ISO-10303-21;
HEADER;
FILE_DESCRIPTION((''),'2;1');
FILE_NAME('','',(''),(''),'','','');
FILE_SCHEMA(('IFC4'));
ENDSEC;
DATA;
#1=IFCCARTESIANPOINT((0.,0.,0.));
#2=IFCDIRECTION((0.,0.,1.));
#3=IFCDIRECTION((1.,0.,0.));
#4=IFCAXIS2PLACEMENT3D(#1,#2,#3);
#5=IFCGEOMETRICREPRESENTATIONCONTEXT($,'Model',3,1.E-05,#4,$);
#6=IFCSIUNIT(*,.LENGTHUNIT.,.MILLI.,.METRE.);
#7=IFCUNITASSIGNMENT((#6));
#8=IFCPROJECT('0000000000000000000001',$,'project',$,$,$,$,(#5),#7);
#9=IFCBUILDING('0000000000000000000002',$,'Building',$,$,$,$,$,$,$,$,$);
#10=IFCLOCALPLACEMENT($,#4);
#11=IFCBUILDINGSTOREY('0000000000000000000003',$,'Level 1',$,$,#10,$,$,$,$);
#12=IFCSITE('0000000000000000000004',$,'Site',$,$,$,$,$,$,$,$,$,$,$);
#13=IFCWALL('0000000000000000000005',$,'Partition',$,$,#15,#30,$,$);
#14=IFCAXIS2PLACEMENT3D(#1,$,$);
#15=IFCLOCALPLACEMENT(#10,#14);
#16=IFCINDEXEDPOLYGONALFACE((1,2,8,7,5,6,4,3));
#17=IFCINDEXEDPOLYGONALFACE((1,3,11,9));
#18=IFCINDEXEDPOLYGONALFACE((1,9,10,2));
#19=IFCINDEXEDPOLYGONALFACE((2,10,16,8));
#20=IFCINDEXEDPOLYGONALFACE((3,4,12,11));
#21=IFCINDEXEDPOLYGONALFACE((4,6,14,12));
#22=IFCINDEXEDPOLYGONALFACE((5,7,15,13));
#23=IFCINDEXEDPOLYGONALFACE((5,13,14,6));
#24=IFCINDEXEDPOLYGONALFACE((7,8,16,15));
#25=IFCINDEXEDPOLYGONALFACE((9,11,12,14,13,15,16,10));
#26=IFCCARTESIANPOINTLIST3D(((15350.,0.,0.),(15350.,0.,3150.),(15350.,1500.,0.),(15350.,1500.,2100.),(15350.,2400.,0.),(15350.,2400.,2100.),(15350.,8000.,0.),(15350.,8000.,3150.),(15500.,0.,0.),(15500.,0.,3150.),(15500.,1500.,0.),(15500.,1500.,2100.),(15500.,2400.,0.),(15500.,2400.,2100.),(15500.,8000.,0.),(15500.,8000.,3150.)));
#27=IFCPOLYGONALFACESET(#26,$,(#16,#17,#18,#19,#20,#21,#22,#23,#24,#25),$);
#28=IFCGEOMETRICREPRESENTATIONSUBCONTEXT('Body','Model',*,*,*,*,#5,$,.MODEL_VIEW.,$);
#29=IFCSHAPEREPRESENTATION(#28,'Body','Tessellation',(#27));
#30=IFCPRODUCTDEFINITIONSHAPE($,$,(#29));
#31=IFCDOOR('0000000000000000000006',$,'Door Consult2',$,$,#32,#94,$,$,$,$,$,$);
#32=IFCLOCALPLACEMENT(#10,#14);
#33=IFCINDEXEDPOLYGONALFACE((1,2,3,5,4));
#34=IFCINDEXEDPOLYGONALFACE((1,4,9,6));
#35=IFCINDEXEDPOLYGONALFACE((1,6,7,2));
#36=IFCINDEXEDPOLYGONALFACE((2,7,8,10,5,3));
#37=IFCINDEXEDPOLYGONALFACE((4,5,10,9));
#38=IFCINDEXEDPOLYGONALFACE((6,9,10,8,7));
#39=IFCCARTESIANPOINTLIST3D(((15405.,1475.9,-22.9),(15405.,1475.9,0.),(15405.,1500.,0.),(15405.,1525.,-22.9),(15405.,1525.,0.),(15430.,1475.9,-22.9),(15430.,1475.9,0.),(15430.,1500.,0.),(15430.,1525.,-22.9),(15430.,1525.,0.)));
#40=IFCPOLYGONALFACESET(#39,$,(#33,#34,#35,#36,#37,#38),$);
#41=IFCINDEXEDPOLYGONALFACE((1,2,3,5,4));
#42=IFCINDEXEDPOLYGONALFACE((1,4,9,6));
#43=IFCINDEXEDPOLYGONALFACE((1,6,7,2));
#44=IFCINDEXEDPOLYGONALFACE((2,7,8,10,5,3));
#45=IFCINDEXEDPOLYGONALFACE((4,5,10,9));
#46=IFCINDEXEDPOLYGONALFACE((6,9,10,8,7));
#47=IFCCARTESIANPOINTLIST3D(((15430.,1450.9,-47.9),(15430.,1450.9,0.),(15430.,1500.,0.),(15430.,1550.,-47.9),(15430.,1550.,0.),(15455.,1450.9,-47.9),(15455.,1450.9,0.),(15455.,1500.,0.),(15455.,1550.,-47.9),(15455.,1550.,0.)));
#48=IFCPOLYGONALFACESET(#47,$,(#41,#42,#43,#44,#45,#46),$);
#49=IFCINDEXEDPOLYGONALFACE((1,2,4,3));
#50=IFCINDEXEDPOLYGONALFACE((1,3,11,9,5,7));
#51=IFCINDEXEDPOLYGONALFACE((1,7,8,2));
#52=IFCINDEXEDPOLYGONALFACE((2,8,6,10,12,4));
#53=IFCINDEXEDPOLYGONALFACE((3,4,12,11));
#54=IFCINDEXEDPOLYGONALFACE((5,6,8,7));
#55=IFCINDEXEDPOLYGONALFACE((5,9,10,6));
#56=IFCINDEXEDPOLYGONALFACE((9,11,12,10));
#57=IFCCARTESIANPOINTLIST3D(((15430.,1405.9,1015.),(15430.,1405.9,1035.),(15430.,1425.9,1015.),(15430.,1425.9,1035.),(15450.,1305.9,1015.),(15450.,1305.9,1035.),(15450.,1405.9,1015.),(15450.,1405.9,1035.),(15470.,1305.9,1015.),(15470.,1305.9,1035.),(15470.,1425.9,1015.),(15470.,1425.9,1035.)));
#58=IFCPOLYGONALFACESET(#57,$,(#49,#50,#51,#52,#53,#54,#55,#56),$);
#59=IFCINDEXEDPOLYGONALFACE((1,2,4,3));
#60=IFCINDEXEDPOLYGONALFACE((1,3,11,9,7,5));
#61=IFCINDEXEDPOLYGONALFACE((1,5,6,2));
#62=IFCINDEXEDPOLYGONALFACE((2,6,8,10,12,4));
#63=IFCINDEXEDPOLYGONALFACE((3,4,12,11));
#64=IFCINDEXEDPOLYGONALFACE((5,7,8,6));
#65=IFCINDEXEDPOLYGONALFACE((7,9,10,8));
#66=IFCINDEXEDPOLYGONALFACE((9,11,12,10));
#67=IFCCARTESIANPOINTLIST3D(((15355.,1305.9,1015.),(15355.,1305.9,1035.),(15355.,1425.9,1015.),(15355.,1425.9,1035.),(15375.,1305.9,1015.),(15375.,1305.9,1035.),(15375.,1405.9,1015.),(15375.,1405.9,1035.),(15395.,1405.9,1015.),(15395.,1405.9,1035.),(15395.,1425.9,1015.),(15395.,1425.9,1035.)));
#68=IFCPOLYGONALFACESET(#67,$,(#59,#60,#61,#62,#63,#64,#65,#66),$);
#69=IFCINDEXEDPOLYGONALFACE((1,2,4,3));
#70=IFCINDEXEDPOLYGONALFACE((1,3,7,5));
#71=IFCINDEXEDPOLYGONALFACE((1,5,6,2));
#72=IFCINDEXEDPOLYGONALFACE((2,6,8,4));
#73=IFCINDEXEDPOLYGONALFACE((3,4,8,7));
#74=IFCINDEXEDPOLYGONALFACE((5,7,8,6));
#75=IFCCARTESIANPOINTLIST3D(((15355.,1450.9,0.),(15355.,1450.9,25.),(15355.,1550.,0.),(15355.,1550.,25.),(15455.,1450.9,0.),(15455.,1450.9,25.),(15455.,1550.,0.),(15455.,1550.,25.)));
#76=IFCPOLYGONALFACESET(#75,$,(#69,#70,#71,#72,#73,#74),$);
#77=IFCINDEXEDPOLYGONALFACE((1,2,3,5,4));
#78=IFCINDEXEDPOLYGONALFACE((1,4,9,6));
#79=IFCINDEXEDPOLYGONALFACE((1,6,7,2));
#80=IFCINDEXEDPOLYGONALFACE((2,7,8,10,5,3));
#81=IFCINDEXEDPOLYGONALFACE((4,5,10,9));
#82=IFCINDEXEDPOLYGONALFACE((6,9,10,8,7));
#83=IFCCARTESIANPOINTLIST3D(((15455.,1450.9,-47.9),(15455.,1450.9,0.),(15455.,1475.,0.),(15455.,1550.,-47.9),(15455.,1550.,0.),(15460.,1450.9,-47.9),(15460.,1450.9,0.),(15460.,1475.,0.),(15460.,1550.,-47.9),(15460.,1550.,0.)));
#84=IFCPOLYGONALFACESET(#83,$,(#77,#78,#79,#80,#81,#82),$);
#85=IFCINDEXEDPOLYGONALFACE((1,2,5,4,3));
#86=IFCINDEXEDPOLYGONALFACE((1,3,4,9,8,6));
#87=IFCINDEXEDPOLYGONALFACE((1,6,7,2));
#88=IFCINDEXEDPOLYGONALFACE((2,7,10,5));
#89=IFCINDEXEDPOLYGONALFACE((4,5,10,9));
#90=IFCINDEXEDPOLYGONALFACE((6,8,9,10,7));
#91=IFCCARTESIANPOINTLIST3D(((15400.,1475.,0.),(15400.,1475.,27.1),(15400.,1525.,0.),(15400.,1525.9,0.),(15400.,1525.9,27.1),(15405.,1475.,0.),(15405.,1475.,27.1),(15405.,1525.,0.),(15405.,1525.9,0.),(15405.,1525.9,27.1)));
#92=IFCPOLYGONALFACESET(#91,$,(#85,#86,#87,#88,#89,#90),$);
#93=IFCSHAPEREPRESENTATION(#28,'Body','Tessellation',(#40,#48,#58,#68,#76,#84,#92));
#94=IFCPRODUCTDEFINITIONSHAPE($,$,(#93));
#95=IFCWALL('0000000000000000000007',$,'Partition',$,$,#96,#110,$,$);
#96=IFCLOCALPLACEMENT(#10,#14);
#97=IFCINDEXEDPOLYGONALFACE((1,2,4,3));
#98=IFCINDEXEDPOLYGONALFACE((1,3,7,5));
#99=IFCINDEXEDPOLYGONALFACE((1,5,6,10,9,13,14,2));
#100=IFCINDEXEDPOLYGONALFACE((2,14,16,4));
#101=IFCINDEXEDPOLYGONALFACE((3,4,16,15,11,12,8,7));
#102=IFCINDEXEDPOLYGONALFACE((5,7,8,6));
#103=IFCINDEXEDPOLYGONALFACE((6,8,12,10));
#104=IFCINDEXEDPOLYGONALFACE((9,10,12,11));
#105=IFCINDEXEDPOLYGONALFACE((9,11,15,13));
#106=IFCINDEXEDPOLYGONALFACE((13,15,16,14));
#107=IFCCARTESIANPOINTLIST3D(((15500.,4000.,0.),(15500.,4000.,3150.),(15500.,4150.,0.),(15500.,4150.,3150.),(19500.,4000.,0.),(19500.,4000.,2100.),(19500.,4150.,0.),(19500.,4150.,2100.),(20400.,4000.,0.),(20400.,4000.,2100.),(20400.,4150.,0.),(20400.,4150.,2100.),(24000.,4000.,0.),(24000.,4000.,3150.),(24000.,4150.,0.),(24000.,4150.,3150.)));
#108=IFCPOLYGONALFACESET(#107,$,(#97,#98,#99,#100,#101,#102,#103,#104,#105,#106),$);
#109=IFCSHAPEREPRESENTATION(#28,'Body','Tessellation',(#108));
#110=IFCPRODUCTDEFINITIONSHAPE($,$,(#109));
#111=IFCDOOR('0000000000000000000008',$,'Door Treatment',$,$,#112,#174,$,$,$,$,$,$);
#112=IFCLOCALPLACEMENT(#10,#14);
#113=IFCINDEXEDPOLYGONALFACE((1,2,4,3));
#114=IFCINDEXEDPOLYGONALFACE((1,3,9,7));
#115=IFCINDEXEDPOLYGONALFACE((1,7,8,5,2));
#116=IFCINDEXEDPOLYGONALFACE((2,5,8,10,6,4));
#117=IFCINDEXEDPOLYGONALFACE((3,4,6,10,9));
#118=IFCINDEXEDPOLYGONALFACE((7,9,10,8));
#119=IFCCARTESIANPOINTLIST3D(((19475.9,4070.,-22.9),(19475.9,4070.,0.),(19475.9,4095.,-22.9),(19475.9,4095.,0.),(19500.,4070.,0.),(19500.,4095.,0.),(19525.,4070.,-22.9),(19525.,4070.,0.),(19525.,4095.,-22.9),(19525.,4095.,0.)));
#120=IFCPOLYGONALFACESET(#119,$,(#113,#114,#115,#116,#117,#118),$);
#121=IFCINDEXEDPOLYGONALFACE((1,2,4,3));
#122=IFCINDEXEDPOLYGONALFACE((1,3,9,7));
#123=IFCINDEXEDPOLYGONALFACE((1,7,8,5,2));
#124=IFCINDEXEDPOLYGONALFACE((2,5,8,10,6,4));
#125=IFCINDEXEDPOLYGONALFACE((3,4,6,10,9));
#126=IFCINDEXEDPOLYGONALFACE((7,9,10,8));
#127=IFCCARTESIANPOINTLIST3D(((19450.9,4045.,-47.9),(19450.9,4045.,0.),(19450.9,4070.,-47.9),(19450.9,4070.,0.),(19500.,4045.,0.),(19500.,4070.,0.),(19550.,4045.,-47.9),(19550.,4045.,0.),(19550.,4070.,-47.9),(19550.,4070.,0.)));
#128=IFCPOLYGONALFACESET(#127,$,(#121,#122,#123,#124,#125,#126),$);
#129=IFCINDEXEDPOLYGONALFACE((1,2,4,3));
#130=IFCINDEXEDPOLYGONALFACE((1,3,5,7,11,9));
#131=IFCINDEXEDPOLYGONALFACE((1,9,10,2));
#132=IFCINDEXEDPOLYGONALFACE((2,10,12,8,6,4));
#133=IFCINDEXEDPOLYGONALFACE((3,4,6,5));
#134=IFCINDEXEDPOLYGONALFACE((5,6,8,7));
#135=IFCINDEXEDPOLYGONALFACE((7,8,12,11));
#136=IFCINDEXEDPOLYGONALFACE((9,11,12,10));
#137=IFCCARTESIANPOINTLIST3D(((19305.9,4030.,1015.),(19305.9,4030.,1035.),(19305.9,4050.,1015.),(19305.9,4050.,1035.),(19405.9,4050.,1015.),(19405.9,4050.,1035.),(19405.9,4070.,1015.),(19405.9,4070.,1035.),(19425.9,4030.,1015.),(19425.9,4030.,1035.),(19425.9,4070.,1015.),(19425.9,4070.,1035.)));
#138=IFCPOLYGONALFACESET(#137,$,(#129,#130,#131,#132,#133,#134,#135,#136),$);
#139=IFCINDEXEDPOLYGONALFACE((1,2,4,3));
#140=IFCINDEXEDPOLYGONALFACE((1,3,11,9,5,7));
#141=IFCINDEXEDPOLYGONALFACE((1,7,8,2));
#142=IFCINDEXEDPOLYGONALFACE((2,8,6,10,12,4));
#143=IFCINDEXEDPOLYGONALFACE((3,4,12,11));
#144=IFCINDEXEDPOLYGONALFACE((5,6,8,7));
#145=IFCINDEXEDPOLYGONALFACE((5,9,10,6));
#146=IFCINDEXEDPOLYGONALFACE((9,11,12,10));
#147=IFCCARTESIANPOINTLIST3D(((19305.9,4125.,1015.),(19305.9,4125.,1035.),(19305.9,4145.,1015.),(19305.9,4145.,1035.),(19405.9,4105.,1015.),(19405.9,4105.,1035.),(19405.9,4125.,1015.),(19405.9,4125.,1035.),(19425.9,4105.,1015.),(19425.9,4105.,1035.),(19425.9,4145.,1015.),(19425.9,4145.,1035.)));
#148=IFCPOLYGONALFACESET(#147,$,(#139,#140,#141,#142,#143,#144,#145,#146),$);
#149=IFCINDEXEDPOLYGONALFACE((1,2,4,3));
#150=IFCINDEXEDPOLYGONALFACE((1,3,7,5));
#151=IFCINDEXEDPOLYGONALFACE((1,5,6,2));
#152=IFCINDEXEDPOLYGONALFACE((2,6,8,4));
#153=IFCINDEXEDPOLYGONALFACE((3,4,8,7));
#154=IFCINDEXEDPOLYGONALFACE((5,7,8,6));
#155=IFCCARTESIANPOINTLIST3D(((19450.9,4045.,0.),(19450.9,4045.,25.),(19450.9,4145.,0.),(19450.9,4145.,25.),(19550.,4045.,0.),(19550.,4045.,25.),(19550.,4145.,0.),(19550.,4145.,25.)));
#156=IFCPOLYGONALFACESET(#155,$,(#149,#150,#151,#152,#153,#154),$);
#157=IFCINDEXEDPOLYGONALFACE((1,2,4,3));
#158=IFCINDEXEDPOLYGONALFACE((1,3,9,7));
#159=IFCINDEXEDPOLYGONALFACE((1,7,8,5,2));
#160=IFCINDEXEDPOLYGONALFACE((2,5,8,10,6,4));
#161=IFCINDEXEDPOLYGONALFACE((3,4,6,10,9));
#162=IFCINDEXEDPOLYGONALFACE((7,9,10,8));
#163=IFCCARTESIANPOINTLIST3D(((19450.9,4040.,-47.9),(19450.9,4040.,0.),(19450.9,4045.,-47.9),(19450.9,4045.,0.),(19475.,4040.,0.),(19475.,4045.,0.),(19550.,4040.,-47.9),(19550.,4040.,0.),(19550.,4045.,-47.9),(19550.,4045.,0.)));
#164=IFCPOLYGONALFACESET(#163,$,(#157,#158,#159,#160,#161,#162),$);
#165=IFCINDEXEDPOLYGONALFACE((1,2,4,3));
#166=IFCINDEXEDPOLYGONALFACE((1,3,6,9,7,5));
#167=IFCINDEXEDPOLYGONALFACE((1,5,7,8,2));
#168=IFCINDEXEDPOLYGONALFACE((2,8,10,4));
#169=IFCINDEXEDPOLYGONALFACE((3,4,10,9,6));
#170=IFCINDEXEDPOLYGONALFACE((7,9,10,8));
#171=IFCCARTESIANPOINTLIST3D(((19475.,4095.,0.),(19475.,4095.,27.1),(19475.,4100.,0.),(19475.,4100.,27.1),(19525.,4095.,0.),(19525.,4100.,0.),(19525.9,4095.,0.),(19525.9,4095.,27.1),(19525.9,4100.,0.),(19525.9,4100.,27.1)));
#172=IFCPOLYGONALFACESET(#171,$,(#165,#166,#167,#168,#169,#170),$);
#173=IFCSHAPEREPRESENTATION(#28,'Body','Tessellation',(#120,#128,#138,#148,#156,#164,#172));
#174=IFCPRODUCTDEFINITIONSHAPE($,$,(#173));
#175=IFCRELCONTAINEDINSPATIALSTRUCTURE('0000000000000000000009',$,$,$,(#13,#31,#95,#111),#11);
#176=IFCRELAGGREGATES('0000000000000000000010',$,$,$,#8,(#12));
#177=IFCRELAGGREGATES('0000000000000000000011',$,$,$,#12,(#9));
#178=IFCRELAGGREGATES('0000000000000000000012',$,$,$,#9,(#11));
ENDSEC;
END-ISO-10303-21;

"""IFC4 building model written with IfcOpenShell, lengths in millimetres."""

from ifc_helpers import new_model, si_unit, frame, origin_with_axes, place, context, subcontext, project, spatial, line, indexed_curve, outline, extrude, element, fill, save


model = new_model("IFC4")

# Units and contexts
model_context = context("Model", 3, precision=1e-05, world=origin_with_axes())
body_context = subcontext(model_context, "Body", "Model", "MODEL_VIEW")
ifc_project = project(units=[si_unit("LENGTHUNIT", "METRE", prefix="MILLI")], contexts=[model_context])

# Site, building, storey
site = spatial("IfcSite", under=ifc_project, Name="Site")
building = spatial("IfcBuilding", under=site, Name="Building")
storey_placement = place(None, origin_with_axes())
storey = spatial("IfcBuildingStorey", under=building, at=storey_placement, Name="Level 1")

# Walls, openings, doors
wall_1_placement = place(storey_placement, frame((15500.0, 0.0, 0.0), z_axis=(0.0, 0.0, 1.0), x_axis=(0.0, 1.0, 0.0)))
wall_1 = element("IfcWall", 1, at=wall_1_placement, inside=storey, Name="Partition", context=body_context, shape_type="SweptSolid", body=[
    extrude(outline(indexed_curve([(0.0, 0.0), (0.0, 150.0), (8000.0, 150.0), (8000.0, 0.0), (0.0, 0.0)], self_intersect=False)), origin_with_axes(), (0.0, 0.0, 1.0), 3150.0),
])
opening_1_placement = place(wall_1_placement, frame((1500.0, -100.0, 0.0), z_axis=(0.0, 0.0, 1.0), x_axis=(1.0, 0.0, 0.0)))
opening_1 = element("IfcOpeningElement", 2, at=opening_1_placement, cuts=wall_1, context=body_context, shape_type="SweptSolid", body=[
    extrude(outline(indexed_curve([(0.0, 0.0), (0.0, 350.0), (900.0, 350.0), (900.0, 0.0), (0.0, 0.0)], self_intersect=False)), origin_with_axes(), (0.0, 0.0, 1.0), 2100.0),
])
door_1_placement = place(opening_1_placement, frame((0.0, 145.0, 0.0), z_axis=(0.0, 0.0, 1.0), x_axis=(1.0, 0.0, 0.0)))
door_1 = element("IfcDoor", 3, at=door_1_placement, inside=storey, Name="Door Consult2", context=body_context, shape_type="SweptSolid", body=[
    extrude(outline(indexed_curve([(0.0, 0.0), (0.0, 2.1), (0.9, 2.1), (0.9, 0.0), (-24.1, 0.0), (-24.1, -22.9), (25.0, -22.9), (25.0, 0.0)], segments=[line(1, 2, 3, 4, 5, 6, 7, 8, 1)])), frame((0.0, 25.0, 0.0), z_axis=(0.0, -1.0, 0.0), x_axis=(1.0, 0.0, 0.0)), (0.0, 0.0, -1.0), 25.0),
    extrude(outline(indexed_curve([(0.0, 0.0), (0.0, 2.1), (0.9, 2.1), (0.9, 0.0), (-49.1, 0.0), (-49.1, -47.9), (50.0, -47.9), (50.0, 0.0)], segments=[line(1, 2, 3, 4, 5, 6, 7, 8, 1)])), frame((0.0, 0.0, 0.0), z_axis=(0.0, -1.0, 0.0), x_axis=(1.0, 0.0, 0.0)), (0.0, 0.0, -1.0), 25.0),
    extrude(outline(indexed_curve([(0.0, 0.0), (-49.1, 0.0), (-49.1, 35.0), (0.0, 35.0)], segments=[line(1, 2, 3, 4, 1)])), frame((25.0, 25.0, 25.0), z_axis=(0.0, 0.0, 1.0), x_axis=(1.0, 0.0, 0.0)), (0.0, 0.0, 1.0), -47.9),
    extrude(outline(indexed_curve([(0.0, 0.0), (0.0, -40.0), (-120.0, -40.0), (-120.0, -20.0), (-20.0, -20.0), (-20.0, 0.0)], segments=[line(1, 2, 3, 4, 5, 6, 1)])), frame((-74.1, 25.0, 1015.0), z_axis=(0.0, 0.0, 1.0), x_axis=(1.0, 0.0, 0.0)), (0.0, 0.0, 1.0), 20.0),
    extrude(outline(indexed_curve([(0.0, 0.0), (0.0, 40.0), (-120.0, 40.0), (-120.0, 20.0), (-20.0, 20.0), (-20.0, 0.0)], segments=[line(1, 2, 3, 4, 5, 6, 1)])), frame((-74.1, 60.0, 1015.0), z_axis=(0.0, 0.0, 1.0), x_axis=(1.0, 0.0, 0.0)), (0.0, 0.0, 1.0), 20.0),
    extrude(outline(indexed_curve([(0.0, 0.0), (-99.1, 0.0), (-99.1, 100.0), (0.0, 100.0)], segments=[line(1, 2, 3, 4, 1)])), frame((50.0, 0.0, 0.0), z_axis=(0.0, 0.0, 1.0), x_axis=(1.0, 0.0, 0.0)), (0.0, 0.0, 1.0), 25.0),
    extrude(outline(indexed_curve([(0.0, 0.0), (0.0, 27.1), (50.9, 27.1), (50.9, 0.0), (-24.1, 0.0), (-24.1, -47.9), (75.0, -47.9), (75.0, 0.0)], segments=[line(1, 2, 3, 4, 5, 6, 7, 8, 1)])), frame((-25.0, -5.0, 0.0), z_axis=(0.0, -1.0, 0.0), x_axis=(1.0, 0.0, 0.0)), (0.0, 0.0, -1.0), 5.0),
    extrude(outline(indexed_curve([(0.0, 0.0), (0.0, 27.1), (50.9, 27.1), (50.9, 0.0), (0.9, 0.0), (0.9, -22.9), (50.0, -22.9), (50.0, 0.0)], segments=[line(1, 2, 3, 4, 5, 6, 7, 8, 1)])), frame((-25.0, 50.0, 0.0), z_axis=(0.0, -1.0, 0.0), x_axis=(1.0, 0.0, 0.0)), (0.0, 0.0, -1.0), 5.0),
])
fill(opening_1, door_1)
wall_2_placement = place(storey_placement, frame((15500.0, 4000.0, 0.0), z_axis=(0.0, 0.0, 1.0), x_axis=(1.0, 0.0, 0.0)))
wall_2 = element("IfcWall", 4, at=wall_2_placement, inside=storey, Name="Partition", context=body_context, shape_type="SweptSolid", body=[
    extrude(outline(indexed_curve([(0.0, 0.0), (0.0, 150.0), (8500.0, 150.0), (8500.0, 0.0), (0.0, 0.0)], self_intersect=False)), origin_with_axes(), (0.0, 0.0, 1.0), 3150.0),
])
opening_2_placement = place(wall_2_placement, frame((4000.0, -100.0, 0.0), z_axis=(0.0, 0.0, 1.0), x_axis=(1.0, 0.0, 0.0)))
opening_2 = element("IfcOpeningElement", 5, at=opening_2_placement, cuts=wall_2, context=body_context, shape_type="SweptSolid", body=[
    extrude(outline(indexed_curve([(0.0, 0.0), (0.0, 350.0), (900.0, 350.0), (900.0, 0.0), (0.0, 0.0)], self_intersect=False)), origin_with_axes(), (0.0, 0.0, 1.0), 2100.0),
])
door_2_placement = place(opening_2_placement, frame((0.0, 145.0, 0.0), z_axis=(0.0, 0.0, 1.0), x_axis=(1.0, 0.0, 0.0)))
door_2 = element("IfcDoor", 6, at=door_2_placement, inside=storey, Name="Door Treatment", context=body_context, shape_type="SweptSolid", body=[
    extrude(outline(indexed_curve([(0.0, 0.0), (0.0, 2.1), (0.9, 2.1), (0.9, 0.0), (-24.1, 0.0), (-24.1, -22.9), (25.0, -22.9), (25.0, 0.0)], segments=[line(1, 2, 3, 4, 5, 6, 7, 8, 1)])), frame((0.0, 25.0, 0.0), z_axis=(0.0, -1.0, 0.0), x_axis=(1.0, 0.0, 0.0)), (0.0, 0.0, -1.0), 25.0),
    extrude(outline(indexed_curve([(0.0, 0.0), (0.0, 2.1), (0.9, 2.1), (0.9, 0.0), (-49.1, 0.0), (-49.1, -47.9), (50.0, -47.9), (50.0, 0.0)], segments=[line(1, 2, 3, 4, 5, 6, 7, 8, 1)])), frame((0.0, 0.0, 0.0), z_axis=(0.0, -1.0, 0.0), x_axis=(1.0, 0.0, 0.0)), (0.0, 0.0, -1.0), 25.0),
    extrude(outline(indexed_curve([(0.0, 0.0), (-49.1, 0.0), (-49.1, 35.0), (0.0, 35.0)], segments=[line(1, 2, 3, 4, 1)])), frame((25.0, 25.0, 25.0), z_axis=(0.0, 0.0, 1.0), x_axis=(1.0, 0.0, 0.0)), (0.0, 0.0, 1.0), -47.9),
    extrude(outline(indexed_curve([(0.0, 0.0), (0.0, -40.0), (-120.0, -40.0), (-120.0, -20.0), (-20.0, -20.0), (-20.0, 0.0)], segments=[line(1, 2, 3, 4, 5, 6, 1)])), frame((-74.1, 25.0, 1015.0), z_axis=(0.0, 0.0, 1.0), x_axis=(1.0, 0.0, 0.0)), (0.0, 0.0, 1.0), 20.0),
    extrude(outline(indexed_curve([(0.0, 0.0), (0.0, 40.0), (-120.0, 40.0), (-120.0, 20.0), (-20.0, 20.0), (-20.0, 0.0)], segments=[line(1, 2, 3, 4, 5, 6, 1)])), frame((-74.1, 60.0, 1015.0), z_axis=(0.0, 0.0, 1.0), x_axis=(1.0, 0.0, 0.0)), (0.0, 0.0, 1.0), 20.0),
    extrude(outline(indexed_curve([(0.0, 0.0), (-99.1, 0.0), (-99.1, 100.0), (0.0, 100.0)], segments=[line(1, 2, 3, 4, 1)])), frame((50.0, 0.0, 0.0), z_axis=(0.0, 0.0, 1.0), x_axis=(1.0, 0.0, 0.0)), (0.0, 0.0, 1.0), 25.0),
    extrude(outline(indexed_curve([(0.0, 0.0), (0.0, 27.1), (50.9, 27.1), (50.9, 0.0), (-24.1, 0.0), (-24.1, -47.9), (75.0, -47.9), (75.0, 0.0)], segments=[line(1, 2, 3, 4, 5, 6, 7, 8, 1)])), frame((-25.0, -5.0, 0.0), z_axis=(0.0, -1.0, 0.0), x_axis=(1.0, 0.0, 0.0)), (0.0, 0.0, -1.0), 5.0),
    extrude(outline(indexed_curve([(0.0, 0.0), (0.0, 27.1), (50.9, 27.1), (50.9, 0.0), (0.9, 0.0), (0.9, -22.9), (50.0, -22.9), (50.0, 0.0)], segments=[line(1, 2, 3, 4, 5, 6, 7, 8, 1)])), frame((-25.0, 50.0, 0.0), z_axis=(0.0, -1.0, 0.0), x_axis=(1.0, 0.0, 0.0)), (0.0, 0.0, -1.0), 5.0),
])
fill(opening_2, door_2)

save(model, "model.ifc")
